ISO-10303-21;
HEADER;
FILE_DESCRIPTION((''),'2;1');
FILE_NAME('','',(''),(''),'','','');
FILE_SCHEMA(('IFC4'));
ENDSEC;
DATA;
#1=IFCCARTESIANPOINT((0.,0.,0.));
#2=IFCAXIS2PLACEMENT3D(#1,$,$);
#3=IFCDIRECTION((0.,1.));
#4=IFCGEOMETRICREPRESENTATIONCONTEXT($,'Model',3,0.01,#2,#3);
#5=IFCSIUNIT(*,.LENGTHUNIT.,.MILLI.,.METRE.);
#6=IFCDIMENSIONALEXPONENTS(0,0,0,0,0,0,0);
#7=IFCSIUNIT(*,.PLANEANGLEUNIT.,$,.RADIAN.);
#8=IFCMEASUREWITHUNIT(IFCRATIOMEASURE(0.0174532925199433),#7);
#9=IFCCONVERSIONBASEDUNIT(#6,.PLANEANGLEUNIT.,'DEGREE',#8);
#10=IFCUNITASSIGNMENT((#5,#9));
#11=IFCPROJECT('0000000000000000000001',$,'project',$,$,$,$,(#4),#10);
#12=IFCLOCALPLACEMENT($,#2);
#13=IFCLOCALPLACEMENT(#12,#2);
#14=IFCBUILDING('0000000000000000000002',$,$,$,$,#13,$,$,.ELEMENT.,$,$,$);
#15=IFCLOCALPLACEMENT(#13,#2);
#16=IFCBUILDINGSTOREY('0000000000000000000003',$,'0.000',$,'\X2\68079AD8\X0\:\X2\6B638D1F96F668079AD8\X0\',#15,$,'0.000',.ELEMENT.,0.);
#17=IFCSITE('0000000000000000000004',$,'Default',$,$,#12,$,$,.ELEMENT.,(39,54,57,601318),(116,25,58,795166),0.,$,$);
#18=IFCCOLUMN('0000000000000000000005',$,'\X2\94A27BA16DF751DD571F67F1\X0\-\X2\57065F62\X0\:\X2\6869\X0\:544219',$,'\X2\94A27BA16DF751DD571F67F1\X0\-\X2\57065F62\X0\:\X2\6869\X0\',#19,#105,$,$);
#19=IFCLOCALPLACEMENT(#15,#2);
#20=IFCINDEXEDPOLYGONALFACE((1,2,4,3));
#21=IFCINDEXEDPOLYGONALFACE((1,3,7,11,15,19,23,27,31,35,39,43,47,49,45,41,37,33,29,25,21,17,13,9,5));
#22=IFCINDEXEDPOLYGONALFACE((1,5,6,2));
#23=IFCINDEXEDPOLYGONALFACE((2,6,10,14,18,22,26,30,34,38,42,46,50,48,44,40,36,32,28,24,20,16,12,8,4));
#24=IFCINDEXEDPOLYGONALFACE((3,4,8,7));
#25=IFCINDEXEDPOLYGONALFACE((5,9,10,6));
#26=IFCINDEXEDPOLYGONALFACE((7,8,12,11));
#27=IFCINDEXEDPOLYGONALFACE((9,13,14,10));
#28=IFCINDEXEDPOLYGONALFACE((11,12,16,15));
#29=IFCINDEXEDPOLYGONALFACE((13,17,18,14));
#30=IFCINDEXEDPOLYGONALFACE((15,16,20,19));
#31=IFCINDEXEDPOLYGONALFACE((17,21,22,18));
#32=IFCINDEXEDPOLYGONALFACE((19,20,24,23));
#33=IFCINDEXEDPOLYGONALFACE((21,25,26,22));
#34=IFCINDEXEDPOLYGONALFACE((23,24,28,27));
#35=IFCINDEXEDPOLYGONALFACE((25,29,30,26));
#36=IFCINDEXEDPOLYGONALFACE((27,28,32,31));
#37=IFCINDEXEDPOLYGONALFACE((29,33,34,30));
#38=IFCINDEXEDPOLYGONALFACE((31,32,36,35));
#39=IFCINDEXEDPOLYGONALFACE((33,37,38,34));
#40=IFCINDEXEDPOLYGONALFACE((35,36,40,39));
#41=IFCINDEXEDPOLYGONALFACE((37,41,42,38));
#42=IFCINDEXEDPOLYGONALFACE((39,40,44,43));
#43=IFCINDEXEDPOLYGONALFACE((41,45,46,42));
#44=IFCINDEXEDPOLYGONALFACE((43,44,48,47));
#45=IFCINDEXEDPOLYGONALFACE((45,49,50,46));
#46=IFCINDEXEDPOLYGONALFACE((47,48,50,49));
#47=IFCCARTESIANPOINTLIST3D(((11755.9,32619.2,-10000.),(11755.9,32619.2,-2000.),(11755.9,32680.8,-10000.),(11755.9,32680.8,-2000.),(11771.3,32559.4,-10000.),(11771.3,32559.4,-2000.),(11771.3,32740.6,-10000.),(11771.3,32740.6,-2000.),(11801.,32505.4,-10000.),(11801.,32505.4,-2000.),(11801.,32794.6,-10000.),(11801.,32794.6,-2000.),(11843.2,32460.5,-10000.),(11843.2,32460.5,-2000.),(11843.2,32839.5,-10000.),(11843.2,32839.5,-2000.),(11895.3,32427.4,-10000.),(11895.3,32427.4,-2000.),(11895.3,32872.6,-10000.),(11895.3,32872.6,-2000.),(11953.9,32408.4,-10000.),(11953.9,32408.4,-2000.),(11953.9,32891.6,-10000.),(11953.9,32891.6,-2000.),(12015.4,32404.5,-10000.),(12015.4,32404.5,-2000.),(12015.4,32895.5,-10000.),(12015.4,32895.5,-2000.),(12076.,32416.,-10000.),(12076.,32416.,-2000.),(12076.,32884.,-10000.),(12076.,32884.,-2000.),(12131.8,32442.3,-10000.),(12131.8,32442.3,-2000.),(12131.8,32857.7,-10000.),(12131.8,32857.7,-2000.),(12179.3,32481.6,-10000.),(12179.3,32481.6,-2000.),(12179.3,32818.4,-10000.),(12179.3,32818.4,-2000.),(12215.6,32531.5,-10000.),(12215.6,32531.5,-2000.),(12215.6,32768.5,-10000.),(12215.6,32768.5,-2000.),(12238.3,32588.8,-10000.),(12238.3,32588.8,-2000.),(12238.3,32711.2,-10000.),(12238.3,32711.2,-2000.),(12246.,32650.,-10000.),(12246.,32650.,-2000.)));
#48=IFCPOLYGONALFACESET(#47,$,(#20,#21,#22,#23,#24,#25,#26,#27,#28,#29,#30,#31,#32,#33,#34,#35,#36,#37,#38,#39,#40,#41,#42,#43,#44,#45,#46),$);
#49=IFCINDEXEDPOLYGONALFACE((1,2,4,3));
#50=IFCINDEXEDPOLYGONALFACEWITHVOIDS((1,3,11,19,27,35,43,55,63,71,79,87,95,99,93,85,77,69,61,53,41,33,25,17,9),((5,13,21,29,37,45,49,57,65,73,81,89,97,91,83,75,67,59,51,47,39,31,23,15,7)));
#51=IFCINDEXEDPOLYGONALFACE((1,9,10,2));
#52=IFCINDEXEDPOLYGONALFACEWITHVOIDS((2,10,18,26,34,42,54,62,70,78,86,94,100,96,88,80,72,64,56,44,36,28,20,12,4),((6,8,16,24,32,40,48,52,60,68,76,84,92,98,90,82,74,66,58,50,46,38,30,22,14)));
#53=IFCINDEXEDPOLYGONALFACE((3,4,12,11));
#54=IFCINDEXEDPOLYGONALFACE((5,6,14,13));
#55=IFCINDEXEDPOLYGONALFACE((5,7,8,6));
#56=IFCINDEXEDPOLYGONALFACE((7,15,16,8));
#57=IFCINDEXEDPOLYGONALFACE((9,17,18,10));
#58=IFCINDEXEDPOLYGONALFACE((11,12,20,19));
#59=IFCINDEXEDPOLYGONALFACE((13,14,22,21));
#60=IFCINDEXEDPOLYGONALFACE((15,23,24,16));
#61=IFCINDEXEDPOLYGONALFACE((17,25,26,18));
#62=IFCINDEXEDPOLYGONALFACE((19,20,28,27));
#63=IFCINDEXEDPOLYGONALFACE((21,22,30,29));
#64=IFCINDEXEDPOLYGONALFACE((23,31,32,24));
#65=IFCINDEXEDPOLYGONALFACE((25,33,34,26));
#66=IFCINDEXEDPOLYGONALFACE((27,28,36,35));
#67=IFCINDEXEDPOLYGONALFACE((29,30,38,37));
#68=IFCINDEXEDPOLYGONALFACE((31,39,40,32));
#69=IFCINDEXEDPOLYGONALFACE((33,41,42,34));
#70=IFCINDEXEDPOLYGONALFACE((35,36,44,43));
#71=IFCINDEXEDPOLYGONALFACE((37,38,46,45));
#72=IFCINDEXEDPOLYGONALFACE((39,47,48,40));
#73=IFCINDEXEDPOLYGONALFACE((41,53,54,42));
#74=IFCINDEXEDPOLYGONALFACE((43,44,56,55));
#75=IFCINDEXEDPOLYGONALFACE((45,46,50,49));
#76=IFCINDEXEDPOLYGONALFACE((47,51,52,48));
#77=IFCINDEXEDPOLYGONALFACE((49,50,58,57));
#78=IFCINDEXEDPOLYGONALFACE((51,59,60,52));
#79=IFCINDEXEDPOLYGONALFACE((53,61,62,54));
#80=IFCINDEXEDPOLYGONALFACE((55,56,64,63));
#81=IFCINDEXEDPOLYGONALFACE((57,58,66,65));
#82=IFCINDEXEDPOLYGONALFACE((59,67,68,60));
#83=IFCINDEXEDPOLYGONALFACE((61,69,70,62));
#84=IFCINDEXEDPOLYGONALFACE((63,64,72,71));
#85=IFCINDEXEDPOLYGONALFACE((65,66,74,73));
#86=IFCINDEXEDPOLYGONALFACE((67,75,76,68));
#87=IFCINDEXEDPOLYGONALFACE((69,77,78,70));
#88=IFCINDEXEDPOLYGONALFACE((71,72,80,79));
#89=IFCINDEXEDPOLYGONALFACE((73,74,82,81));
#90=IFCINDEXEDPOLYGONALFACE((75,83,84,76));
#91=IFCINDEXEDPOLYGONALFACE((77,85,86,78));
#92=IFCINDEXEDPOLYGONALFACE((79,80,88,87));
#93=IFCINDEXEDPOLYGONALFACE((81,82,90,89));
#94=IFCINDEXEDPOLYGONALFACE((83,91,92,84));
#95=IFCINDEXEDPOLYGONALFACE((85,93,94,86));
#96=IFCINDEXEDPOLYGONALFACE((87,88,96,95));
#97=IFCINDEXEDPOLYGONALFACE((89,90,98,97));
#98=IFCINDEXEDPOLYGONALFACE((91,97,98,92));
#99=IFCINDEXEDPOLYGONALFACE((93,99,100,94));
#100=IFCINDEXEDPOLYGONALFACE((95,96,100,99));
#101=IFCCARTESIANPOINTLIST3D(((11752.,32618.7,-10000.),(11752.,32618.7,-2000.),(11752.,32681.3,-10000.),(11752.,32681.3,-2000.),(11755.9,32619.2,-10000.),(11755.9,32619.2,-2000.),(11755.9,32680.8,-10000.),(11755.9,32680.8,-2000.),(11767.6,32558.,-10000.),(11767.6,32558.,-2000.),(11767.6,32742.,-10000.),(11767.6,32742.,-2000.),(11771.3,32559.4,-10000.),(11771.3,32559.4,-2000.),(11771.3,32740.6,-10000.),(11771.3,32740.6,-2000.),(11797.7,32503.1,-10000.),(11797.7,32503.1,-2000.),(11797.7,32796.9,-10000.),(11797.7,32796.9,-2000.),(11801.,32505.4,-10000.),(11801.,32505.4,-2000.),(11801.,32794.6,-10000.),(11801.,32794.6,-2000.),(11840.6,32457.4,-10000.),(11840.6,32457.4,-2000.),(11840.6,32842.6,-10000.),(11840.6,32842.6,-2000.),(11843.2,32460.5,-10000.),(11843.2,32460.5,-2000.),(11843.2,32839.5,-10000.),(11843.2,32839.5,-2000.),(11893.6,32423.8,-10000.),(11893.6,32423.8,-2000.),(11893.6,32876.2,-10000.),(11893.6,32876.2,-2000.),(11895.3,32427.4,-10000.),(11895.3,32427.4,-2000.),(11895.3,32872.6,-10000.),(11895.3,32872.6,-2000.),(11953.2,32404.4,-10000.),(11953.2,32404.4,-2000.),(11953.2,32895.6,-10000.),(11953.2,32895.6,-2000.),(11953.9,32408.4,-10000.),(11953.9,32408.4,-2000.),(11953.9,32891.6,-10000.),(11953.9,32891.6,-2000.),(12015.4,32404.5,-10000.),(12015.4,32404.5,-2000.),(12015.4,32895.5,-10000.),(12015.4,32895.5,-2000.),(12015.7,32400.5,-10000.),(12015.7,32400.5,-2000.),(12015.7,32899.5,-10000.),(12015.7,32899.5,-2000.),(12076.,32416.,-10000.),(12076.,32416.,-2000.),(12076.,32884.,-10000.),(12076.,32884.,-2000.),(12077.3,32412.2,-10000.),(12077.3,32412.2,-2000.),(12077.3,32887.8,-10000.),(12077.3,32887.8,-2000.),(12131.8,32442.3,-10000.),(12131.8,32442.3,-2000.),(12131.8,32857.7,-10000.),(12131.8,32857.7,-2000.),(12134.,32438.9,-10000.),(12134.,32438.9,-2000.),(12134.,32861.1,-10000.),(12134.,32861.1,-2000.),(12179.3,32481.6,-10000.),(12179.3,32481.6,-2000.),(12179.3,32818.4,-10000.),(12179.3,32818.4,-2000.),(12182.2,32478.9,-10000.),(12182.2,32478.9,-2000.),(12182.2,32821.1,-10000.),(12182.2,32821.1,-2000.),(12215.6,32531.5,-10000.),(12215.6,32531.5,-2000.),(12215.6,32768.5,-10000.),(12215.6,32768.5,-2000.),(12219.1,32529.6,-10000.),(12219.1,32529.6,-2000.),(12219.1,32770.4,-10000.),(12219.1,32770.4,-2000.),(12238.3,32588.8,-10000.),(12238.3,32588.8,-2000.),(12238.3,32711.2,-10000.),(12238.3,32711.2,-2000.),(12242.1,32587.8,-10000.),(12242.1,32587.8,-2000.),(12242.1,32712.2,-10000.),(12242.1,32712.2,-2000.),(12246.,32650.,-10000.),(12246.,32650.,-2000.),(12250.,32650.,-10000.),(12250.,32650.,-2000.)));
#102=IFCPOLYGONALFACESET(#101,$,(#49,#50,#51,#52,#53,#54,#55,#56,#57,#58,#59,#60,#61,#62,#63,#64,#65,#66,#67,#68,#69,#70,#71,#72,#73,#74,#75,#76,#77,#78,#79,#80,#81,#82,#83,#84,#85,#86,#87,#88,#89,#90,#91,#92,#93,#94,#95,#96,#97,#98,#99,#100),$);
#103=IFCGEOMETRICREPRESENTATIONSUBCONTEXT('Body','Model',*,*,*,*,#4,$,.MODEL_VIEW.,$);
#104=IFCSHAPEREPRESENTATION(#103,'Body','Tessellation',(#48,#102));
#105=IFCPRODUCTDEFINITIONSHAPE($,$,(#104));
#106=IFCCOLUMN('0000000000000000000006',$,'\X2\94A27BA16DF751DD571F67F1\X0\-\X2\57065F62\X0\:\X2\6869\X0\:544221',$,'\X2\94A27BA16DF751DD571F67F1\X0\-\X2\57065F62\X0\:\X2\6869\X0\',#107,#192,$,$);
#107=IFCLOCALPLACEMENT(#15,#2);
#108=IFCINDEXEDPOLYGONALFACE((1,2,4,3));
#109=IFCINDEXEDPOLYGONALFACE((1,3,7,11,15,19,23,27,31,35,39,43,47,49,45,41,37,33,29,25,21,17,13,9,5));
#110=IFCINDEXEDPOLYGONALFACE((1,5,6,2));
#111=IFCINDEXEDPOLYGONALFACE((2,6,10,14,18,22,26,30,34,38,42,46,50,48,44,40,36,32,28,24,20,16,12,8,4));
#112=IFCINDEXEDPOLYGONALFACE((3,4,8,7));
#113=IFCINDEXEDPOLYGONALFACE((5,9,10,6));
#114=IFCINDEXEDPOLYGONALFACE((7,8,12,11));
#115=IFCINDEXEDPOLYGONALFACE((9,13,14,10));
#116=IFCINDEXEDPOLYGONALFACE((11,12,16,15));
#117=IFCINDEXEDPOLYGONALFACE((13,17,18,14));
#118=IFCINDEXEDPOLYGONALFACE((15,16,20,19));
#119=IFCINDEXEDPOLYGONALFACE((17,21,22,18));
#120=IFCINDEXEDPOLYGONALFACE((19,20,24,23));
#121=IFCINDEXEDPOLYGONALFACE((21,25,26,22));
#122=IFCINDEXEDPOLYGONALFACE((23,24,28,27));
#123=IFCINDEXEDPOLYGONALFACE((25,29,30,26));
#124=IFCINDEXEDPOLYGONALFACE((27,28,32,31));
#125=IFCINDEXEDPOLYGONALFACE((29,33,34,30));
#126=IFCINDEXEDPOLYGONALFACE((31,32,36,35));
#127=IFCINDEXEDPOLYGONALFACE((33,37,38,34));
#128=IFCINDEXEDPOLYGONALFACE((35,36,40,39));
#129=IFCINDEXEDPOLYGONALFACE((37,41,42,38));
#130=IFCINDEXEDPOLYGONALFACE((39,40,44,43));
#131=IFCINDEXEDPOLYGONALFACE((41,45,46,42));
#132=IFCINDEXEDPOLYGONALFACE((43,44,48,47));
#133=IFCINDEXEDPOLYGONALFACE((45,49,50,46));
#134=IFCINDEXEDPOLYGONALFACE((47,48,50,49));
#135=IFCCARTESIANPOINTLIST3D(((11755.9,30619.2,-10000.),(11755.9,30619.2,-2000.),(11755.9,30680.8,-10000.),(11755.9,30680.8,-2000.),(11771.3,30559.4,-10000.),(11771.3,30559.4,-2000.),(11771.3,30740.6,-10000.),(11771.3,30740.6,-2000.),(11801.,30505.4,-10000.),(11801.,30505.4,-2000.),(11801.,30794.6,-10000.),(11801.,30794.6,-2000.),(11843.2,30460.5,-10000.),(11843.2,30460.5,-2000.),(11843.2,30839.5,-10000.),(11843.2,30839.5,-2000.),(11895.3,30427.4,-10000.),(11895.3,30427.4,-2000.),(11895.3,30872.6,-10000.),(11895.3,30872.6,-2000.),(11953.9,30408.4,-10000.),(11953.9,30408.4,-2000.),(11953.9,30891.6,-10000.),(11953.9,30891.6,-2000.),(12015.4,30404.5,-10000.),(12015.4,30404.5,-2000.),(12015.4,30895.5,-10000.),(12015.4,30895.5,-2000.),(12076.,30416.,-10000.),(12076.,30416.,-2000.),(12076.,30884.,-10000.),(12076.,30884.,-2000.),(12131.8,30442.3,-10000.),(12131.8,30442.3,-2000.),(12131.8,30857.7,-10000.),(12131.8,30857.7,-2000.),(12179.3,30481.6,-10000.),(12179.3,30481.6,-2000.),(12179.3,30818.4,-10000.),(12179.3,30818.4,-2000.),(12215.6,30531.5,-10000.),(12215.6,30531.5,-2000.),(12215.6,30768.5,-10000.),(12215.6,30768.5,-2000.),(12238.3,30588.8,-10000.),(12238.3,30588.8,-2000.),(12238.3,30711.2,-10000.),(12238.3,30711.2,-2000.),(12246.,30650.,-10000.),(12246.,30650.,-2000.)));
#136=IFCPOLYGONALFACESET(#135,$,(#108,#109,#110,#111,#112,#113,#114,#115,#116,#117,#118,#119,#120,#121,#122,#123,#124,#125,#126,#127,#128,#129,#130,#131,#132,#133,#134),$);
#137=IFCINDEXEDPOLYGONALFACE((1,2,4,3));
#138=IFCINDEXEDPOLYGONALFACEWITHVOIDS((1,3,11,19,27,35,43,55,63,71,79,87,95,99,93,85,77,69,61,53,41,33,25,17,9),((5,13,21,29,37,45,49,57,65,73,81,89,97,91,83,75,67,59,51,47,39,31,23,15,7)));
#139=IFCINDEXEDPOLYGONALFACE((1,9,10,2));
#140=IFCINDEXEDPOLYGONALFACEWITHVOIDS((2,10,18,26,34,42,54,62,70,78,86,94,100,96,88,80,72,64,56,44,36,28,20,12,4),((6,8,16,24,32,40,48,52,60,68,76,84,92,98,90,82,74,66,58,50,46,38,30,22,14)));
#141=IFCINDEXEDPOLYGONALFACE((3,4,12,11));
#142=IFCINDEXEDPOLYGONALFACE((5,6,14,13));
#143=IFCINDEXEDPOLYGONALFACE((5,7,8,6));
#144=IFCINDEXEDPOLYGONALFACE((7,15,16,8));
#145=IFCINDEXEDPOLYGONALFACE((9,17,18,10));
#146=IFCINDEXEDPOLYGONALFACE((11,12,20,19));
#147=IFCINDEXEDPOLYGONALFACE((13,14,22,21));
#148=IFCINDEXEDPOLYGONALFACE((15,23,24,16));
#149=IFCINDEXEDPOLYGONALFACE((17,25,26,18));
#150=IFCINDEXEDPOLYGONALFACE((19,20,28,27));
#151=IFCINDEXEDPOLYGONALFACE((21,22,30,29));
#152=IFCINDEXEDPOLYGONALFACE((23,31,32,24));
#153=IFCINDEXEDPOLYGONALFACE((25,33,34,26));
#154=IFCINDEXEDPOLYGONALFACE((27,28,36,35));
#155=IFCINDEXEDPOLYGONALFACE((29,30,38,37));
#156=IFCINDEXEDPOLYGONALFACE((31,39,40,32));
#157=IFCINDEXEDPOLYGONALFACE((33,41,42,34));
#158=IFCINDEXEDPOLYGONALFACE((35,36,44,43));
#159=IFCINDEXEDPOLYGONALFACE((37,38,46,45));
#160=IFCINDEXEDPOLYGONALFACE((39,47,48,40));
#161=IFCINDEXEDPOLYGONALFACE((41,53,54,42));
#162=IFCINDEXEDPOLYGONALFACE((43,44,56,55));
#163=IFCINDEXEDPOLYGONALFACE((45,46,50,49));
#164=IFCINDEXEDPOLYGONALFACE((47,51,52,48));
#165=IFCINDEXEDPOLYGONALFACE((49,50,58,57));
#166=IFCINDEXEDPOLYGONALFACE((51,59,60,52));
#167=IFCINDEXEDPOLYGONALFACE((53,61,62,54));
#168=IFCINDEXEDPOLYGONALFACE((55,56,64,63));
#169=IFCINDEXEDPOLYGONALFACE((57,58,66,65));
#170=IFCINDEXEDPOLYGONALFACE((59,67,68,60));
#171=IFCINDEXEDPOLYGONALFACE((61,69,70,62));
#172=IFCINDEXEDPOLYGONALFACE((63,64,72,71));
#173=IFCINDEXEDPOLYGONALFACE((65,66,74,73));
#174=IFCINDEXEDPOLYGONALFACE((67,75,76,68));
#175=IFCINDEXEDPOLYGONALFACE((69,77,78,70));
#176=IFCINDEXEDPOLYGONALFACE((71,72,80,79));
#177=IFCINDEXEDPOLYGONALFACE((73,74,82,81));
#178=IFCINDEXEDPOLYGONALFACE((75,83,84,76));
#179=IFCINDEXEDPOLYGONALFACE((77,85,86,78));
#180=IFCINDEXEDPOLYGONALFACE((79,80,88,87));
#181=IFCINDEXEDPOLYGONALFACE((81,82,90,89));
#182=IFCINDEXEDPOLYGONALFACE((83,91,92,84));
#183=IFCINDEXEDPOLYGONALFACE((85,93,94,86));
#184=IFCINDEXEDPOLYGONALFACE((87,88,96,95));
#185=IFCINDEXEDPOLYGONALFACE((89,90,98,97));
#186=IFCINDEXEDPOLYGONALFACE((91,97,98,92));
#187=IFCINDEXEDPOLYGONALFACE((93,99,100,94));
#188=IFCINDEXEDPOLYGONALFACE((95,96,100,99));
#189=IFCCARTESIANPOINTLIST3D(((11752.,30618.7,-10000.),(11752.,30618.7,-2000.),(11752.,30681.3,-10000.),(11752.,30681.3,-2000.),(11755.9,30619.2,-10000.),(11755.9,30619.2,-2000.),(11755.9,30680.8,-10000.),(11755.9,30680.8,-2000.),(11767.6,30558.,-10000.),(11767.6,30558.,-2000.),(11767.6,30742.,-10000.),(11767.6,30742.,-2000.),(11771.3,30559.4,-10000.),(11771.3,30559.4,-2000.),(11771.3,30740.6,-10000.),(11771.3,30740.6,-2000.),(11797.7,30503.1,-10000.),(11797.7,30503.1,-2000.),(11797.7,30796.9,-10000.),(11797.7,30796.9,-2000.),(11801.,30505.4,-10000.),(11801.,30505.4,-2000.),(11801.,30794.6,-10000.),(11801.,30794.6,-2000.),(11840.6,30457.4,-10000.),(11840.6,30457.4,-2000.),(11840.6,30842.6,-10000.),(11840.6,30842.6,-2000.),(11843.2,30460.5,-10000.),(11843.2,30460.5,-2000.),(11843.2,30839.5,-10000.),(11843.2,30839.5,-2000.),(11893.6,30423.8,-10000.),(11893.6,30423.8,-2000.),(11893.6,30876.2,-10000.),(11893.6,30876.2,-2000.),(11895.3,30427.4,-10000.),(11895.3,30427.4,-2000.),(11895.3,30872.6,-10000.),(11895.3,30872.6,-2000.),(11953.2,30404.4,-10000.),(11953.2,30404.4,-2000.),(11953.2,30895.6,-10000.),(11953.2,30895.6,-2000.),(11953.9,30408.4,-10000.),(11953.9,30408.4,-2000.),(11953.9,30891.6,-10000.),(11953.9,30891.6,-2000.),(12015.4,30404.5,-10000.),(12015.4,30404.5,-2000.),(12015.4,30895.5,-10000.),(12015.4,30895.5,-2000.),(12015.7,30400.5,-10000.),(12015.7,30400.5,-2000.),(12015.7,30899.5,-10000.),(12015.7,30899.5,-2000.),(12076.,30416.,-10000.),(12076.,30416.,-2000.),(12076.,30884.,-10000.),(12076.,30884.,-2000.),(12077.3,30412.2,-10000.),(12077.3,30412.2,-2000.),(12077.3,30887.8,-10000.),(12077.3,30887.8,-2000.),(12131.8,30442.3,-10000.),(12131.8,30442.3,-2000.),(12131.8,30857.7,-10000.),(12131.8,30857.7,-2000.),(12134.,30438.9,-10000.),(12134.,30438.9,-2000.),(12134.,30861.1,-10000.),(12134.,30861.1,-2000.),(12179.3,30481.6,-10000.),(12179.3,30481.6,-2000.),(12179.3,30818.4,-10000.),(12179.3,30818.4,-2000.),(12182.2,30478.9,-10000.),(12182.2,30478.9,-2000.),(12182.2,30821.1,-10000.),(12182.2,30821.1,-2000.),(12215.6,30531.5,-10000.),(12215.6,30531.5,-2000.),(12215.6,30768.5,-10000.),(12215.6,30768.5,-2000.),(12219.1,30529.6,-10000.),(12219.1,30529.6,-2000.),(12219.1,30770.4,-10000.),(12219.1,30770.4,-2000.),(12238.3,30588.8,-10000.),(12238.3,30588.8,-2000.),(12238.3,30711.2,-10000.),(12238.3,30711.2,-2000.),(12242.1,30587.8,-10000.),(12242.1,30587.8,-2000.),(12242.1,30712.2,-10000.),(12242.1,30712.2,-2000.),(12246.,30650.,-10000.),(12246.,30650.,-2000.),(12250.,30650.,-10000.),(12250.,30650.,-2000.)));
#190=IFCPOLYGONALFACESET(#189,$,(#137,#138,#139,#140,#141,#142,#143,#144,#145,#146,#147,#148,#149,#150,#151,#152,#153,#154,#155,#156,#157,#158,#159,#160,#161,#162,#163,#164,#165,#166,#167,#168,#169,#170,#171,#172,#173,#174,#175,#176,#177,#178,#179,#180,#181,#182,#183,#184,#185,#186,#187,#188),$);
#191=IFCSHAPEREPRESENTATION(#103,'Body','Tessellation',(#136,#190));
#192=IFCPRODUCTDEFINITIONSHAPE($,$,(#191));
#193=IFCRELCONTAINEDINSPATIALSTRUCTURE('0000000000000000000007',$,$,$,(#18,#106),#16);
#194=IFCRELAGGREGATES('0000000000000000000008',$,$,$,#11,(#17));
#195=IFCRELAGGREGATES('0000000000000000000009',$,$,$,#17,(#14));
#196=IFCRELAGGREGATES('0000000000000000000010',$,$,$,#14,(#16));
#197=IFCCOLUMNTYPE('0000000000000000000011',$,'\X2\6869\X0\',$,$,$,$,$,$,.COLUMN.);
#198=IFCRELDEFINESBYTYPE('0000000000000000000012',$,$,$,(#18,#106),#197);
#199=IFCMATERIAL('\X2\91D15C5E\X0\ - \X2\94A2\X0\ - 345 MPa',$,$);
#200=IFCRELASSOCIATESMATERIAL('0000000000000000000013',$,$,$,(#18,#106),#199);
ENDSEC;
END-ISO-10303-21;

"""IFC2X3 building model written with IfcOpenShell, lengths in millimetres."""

from ifc_helpers import new_model, entity, si_unit, converted_unit, direction, frame, frame_2d, origin, place, context, subcontext, project, spatial, circle, hollow_circle, extrude, source, transform, mapped, material, type_object, type_shapes, element, save


model = new_model("IFC2X3")

# Units and contexts
model_context = context("Model", 3, precision=0.01, world=origin(), true_north=direction((0.0, 1.0)))
body_context = subcontext(model_context, "Body", "Model", "MODEL_VIEW")
ifc_project = project(units=[si_unit("LENGTHUNIT", "METRE", prefix="MILLI"), converted_unit("PLANEANGLEUNIT", "DEGREE", entity("IfcRatioMeasure", 0.0174532925199433), si_unit("PLANEANGLEUNIT", "RADIAN"), dimensions=[0, 0, 0, 0, 0, 0, 0])], contexts=[model_context])

# Site, building, storey
site_placement = place(None, origin())
site = spatial("IfcSite", under=ifc_project, at=site_placement, Name="Default", CompositionType="ELEMENT", RefLatitude=(39, 54, 57, 601318), RefLongitude=(116, 25, 58, 795166), RefElevation=0.0)
building_placement = place(site_placement, origin())
building = spatial("IfcBuilding", under=site, at=building_placement, CompositionType="ELEMENT")
storey_placement = place(building_placement, origin())
storey = spatial("IfcBuildingStorey", under=building, at=storey_placement, Name="0.000", ObjectType="标高:正负零标高", LongName="0.000", CompositionType="ELEMENT", Elevation=0.0)

# Columns
ifc_material_1 = material(Name="金属 - 钢 - 345 MPa")
column_type = type_object("IfcColumnType", Name="桩", PredefinedType="COLUMN")
shared_shape = source(origin(), body_context, "Body", "SweptSolid", [
    extrude(circle(Radius=246.0, at=frame_2d((0.0, 0.0), x_axis=(1.0, 0.0))), frame((0.0, 0.0, -10000.0)), (0.0, 0.0, 1.0), 8000.0),
    extrude(hollow_circle(Radius=250.0, WallThickness=4.0, at=frame_2d((0.0, 0.0), x_axis=(1.0, 0.0))), frame((0.0, 0.0, -10000.0)), (0.0, 0.0, 1.0), 8000.0),
])
type_shapes(column_type, [shared_shape])
for number, where, name in (
    (1, (12000.0, 32650.0, 0.0), "钢管混凝土柱-圆形:桩:544219"),
    (2, (12000.0, 30650.0, 0.0), "钢管混凝土柱-圆形:桩:544221"),
):
    element("IfcColumn", number, at=place(storey_placement, frame(where)), inside=storey, type_object=column_type, material=ifc_material_1, Name=name, ObjectType="钢管混凝土柱-圆形:桩", context=body_context, shape_type="MappedRepresentation", body=[
        mapped(shared_shape, transform((0.0, 0.0, 0.0), scale=1.0)),
    ])

save(model, "model.ifc")
